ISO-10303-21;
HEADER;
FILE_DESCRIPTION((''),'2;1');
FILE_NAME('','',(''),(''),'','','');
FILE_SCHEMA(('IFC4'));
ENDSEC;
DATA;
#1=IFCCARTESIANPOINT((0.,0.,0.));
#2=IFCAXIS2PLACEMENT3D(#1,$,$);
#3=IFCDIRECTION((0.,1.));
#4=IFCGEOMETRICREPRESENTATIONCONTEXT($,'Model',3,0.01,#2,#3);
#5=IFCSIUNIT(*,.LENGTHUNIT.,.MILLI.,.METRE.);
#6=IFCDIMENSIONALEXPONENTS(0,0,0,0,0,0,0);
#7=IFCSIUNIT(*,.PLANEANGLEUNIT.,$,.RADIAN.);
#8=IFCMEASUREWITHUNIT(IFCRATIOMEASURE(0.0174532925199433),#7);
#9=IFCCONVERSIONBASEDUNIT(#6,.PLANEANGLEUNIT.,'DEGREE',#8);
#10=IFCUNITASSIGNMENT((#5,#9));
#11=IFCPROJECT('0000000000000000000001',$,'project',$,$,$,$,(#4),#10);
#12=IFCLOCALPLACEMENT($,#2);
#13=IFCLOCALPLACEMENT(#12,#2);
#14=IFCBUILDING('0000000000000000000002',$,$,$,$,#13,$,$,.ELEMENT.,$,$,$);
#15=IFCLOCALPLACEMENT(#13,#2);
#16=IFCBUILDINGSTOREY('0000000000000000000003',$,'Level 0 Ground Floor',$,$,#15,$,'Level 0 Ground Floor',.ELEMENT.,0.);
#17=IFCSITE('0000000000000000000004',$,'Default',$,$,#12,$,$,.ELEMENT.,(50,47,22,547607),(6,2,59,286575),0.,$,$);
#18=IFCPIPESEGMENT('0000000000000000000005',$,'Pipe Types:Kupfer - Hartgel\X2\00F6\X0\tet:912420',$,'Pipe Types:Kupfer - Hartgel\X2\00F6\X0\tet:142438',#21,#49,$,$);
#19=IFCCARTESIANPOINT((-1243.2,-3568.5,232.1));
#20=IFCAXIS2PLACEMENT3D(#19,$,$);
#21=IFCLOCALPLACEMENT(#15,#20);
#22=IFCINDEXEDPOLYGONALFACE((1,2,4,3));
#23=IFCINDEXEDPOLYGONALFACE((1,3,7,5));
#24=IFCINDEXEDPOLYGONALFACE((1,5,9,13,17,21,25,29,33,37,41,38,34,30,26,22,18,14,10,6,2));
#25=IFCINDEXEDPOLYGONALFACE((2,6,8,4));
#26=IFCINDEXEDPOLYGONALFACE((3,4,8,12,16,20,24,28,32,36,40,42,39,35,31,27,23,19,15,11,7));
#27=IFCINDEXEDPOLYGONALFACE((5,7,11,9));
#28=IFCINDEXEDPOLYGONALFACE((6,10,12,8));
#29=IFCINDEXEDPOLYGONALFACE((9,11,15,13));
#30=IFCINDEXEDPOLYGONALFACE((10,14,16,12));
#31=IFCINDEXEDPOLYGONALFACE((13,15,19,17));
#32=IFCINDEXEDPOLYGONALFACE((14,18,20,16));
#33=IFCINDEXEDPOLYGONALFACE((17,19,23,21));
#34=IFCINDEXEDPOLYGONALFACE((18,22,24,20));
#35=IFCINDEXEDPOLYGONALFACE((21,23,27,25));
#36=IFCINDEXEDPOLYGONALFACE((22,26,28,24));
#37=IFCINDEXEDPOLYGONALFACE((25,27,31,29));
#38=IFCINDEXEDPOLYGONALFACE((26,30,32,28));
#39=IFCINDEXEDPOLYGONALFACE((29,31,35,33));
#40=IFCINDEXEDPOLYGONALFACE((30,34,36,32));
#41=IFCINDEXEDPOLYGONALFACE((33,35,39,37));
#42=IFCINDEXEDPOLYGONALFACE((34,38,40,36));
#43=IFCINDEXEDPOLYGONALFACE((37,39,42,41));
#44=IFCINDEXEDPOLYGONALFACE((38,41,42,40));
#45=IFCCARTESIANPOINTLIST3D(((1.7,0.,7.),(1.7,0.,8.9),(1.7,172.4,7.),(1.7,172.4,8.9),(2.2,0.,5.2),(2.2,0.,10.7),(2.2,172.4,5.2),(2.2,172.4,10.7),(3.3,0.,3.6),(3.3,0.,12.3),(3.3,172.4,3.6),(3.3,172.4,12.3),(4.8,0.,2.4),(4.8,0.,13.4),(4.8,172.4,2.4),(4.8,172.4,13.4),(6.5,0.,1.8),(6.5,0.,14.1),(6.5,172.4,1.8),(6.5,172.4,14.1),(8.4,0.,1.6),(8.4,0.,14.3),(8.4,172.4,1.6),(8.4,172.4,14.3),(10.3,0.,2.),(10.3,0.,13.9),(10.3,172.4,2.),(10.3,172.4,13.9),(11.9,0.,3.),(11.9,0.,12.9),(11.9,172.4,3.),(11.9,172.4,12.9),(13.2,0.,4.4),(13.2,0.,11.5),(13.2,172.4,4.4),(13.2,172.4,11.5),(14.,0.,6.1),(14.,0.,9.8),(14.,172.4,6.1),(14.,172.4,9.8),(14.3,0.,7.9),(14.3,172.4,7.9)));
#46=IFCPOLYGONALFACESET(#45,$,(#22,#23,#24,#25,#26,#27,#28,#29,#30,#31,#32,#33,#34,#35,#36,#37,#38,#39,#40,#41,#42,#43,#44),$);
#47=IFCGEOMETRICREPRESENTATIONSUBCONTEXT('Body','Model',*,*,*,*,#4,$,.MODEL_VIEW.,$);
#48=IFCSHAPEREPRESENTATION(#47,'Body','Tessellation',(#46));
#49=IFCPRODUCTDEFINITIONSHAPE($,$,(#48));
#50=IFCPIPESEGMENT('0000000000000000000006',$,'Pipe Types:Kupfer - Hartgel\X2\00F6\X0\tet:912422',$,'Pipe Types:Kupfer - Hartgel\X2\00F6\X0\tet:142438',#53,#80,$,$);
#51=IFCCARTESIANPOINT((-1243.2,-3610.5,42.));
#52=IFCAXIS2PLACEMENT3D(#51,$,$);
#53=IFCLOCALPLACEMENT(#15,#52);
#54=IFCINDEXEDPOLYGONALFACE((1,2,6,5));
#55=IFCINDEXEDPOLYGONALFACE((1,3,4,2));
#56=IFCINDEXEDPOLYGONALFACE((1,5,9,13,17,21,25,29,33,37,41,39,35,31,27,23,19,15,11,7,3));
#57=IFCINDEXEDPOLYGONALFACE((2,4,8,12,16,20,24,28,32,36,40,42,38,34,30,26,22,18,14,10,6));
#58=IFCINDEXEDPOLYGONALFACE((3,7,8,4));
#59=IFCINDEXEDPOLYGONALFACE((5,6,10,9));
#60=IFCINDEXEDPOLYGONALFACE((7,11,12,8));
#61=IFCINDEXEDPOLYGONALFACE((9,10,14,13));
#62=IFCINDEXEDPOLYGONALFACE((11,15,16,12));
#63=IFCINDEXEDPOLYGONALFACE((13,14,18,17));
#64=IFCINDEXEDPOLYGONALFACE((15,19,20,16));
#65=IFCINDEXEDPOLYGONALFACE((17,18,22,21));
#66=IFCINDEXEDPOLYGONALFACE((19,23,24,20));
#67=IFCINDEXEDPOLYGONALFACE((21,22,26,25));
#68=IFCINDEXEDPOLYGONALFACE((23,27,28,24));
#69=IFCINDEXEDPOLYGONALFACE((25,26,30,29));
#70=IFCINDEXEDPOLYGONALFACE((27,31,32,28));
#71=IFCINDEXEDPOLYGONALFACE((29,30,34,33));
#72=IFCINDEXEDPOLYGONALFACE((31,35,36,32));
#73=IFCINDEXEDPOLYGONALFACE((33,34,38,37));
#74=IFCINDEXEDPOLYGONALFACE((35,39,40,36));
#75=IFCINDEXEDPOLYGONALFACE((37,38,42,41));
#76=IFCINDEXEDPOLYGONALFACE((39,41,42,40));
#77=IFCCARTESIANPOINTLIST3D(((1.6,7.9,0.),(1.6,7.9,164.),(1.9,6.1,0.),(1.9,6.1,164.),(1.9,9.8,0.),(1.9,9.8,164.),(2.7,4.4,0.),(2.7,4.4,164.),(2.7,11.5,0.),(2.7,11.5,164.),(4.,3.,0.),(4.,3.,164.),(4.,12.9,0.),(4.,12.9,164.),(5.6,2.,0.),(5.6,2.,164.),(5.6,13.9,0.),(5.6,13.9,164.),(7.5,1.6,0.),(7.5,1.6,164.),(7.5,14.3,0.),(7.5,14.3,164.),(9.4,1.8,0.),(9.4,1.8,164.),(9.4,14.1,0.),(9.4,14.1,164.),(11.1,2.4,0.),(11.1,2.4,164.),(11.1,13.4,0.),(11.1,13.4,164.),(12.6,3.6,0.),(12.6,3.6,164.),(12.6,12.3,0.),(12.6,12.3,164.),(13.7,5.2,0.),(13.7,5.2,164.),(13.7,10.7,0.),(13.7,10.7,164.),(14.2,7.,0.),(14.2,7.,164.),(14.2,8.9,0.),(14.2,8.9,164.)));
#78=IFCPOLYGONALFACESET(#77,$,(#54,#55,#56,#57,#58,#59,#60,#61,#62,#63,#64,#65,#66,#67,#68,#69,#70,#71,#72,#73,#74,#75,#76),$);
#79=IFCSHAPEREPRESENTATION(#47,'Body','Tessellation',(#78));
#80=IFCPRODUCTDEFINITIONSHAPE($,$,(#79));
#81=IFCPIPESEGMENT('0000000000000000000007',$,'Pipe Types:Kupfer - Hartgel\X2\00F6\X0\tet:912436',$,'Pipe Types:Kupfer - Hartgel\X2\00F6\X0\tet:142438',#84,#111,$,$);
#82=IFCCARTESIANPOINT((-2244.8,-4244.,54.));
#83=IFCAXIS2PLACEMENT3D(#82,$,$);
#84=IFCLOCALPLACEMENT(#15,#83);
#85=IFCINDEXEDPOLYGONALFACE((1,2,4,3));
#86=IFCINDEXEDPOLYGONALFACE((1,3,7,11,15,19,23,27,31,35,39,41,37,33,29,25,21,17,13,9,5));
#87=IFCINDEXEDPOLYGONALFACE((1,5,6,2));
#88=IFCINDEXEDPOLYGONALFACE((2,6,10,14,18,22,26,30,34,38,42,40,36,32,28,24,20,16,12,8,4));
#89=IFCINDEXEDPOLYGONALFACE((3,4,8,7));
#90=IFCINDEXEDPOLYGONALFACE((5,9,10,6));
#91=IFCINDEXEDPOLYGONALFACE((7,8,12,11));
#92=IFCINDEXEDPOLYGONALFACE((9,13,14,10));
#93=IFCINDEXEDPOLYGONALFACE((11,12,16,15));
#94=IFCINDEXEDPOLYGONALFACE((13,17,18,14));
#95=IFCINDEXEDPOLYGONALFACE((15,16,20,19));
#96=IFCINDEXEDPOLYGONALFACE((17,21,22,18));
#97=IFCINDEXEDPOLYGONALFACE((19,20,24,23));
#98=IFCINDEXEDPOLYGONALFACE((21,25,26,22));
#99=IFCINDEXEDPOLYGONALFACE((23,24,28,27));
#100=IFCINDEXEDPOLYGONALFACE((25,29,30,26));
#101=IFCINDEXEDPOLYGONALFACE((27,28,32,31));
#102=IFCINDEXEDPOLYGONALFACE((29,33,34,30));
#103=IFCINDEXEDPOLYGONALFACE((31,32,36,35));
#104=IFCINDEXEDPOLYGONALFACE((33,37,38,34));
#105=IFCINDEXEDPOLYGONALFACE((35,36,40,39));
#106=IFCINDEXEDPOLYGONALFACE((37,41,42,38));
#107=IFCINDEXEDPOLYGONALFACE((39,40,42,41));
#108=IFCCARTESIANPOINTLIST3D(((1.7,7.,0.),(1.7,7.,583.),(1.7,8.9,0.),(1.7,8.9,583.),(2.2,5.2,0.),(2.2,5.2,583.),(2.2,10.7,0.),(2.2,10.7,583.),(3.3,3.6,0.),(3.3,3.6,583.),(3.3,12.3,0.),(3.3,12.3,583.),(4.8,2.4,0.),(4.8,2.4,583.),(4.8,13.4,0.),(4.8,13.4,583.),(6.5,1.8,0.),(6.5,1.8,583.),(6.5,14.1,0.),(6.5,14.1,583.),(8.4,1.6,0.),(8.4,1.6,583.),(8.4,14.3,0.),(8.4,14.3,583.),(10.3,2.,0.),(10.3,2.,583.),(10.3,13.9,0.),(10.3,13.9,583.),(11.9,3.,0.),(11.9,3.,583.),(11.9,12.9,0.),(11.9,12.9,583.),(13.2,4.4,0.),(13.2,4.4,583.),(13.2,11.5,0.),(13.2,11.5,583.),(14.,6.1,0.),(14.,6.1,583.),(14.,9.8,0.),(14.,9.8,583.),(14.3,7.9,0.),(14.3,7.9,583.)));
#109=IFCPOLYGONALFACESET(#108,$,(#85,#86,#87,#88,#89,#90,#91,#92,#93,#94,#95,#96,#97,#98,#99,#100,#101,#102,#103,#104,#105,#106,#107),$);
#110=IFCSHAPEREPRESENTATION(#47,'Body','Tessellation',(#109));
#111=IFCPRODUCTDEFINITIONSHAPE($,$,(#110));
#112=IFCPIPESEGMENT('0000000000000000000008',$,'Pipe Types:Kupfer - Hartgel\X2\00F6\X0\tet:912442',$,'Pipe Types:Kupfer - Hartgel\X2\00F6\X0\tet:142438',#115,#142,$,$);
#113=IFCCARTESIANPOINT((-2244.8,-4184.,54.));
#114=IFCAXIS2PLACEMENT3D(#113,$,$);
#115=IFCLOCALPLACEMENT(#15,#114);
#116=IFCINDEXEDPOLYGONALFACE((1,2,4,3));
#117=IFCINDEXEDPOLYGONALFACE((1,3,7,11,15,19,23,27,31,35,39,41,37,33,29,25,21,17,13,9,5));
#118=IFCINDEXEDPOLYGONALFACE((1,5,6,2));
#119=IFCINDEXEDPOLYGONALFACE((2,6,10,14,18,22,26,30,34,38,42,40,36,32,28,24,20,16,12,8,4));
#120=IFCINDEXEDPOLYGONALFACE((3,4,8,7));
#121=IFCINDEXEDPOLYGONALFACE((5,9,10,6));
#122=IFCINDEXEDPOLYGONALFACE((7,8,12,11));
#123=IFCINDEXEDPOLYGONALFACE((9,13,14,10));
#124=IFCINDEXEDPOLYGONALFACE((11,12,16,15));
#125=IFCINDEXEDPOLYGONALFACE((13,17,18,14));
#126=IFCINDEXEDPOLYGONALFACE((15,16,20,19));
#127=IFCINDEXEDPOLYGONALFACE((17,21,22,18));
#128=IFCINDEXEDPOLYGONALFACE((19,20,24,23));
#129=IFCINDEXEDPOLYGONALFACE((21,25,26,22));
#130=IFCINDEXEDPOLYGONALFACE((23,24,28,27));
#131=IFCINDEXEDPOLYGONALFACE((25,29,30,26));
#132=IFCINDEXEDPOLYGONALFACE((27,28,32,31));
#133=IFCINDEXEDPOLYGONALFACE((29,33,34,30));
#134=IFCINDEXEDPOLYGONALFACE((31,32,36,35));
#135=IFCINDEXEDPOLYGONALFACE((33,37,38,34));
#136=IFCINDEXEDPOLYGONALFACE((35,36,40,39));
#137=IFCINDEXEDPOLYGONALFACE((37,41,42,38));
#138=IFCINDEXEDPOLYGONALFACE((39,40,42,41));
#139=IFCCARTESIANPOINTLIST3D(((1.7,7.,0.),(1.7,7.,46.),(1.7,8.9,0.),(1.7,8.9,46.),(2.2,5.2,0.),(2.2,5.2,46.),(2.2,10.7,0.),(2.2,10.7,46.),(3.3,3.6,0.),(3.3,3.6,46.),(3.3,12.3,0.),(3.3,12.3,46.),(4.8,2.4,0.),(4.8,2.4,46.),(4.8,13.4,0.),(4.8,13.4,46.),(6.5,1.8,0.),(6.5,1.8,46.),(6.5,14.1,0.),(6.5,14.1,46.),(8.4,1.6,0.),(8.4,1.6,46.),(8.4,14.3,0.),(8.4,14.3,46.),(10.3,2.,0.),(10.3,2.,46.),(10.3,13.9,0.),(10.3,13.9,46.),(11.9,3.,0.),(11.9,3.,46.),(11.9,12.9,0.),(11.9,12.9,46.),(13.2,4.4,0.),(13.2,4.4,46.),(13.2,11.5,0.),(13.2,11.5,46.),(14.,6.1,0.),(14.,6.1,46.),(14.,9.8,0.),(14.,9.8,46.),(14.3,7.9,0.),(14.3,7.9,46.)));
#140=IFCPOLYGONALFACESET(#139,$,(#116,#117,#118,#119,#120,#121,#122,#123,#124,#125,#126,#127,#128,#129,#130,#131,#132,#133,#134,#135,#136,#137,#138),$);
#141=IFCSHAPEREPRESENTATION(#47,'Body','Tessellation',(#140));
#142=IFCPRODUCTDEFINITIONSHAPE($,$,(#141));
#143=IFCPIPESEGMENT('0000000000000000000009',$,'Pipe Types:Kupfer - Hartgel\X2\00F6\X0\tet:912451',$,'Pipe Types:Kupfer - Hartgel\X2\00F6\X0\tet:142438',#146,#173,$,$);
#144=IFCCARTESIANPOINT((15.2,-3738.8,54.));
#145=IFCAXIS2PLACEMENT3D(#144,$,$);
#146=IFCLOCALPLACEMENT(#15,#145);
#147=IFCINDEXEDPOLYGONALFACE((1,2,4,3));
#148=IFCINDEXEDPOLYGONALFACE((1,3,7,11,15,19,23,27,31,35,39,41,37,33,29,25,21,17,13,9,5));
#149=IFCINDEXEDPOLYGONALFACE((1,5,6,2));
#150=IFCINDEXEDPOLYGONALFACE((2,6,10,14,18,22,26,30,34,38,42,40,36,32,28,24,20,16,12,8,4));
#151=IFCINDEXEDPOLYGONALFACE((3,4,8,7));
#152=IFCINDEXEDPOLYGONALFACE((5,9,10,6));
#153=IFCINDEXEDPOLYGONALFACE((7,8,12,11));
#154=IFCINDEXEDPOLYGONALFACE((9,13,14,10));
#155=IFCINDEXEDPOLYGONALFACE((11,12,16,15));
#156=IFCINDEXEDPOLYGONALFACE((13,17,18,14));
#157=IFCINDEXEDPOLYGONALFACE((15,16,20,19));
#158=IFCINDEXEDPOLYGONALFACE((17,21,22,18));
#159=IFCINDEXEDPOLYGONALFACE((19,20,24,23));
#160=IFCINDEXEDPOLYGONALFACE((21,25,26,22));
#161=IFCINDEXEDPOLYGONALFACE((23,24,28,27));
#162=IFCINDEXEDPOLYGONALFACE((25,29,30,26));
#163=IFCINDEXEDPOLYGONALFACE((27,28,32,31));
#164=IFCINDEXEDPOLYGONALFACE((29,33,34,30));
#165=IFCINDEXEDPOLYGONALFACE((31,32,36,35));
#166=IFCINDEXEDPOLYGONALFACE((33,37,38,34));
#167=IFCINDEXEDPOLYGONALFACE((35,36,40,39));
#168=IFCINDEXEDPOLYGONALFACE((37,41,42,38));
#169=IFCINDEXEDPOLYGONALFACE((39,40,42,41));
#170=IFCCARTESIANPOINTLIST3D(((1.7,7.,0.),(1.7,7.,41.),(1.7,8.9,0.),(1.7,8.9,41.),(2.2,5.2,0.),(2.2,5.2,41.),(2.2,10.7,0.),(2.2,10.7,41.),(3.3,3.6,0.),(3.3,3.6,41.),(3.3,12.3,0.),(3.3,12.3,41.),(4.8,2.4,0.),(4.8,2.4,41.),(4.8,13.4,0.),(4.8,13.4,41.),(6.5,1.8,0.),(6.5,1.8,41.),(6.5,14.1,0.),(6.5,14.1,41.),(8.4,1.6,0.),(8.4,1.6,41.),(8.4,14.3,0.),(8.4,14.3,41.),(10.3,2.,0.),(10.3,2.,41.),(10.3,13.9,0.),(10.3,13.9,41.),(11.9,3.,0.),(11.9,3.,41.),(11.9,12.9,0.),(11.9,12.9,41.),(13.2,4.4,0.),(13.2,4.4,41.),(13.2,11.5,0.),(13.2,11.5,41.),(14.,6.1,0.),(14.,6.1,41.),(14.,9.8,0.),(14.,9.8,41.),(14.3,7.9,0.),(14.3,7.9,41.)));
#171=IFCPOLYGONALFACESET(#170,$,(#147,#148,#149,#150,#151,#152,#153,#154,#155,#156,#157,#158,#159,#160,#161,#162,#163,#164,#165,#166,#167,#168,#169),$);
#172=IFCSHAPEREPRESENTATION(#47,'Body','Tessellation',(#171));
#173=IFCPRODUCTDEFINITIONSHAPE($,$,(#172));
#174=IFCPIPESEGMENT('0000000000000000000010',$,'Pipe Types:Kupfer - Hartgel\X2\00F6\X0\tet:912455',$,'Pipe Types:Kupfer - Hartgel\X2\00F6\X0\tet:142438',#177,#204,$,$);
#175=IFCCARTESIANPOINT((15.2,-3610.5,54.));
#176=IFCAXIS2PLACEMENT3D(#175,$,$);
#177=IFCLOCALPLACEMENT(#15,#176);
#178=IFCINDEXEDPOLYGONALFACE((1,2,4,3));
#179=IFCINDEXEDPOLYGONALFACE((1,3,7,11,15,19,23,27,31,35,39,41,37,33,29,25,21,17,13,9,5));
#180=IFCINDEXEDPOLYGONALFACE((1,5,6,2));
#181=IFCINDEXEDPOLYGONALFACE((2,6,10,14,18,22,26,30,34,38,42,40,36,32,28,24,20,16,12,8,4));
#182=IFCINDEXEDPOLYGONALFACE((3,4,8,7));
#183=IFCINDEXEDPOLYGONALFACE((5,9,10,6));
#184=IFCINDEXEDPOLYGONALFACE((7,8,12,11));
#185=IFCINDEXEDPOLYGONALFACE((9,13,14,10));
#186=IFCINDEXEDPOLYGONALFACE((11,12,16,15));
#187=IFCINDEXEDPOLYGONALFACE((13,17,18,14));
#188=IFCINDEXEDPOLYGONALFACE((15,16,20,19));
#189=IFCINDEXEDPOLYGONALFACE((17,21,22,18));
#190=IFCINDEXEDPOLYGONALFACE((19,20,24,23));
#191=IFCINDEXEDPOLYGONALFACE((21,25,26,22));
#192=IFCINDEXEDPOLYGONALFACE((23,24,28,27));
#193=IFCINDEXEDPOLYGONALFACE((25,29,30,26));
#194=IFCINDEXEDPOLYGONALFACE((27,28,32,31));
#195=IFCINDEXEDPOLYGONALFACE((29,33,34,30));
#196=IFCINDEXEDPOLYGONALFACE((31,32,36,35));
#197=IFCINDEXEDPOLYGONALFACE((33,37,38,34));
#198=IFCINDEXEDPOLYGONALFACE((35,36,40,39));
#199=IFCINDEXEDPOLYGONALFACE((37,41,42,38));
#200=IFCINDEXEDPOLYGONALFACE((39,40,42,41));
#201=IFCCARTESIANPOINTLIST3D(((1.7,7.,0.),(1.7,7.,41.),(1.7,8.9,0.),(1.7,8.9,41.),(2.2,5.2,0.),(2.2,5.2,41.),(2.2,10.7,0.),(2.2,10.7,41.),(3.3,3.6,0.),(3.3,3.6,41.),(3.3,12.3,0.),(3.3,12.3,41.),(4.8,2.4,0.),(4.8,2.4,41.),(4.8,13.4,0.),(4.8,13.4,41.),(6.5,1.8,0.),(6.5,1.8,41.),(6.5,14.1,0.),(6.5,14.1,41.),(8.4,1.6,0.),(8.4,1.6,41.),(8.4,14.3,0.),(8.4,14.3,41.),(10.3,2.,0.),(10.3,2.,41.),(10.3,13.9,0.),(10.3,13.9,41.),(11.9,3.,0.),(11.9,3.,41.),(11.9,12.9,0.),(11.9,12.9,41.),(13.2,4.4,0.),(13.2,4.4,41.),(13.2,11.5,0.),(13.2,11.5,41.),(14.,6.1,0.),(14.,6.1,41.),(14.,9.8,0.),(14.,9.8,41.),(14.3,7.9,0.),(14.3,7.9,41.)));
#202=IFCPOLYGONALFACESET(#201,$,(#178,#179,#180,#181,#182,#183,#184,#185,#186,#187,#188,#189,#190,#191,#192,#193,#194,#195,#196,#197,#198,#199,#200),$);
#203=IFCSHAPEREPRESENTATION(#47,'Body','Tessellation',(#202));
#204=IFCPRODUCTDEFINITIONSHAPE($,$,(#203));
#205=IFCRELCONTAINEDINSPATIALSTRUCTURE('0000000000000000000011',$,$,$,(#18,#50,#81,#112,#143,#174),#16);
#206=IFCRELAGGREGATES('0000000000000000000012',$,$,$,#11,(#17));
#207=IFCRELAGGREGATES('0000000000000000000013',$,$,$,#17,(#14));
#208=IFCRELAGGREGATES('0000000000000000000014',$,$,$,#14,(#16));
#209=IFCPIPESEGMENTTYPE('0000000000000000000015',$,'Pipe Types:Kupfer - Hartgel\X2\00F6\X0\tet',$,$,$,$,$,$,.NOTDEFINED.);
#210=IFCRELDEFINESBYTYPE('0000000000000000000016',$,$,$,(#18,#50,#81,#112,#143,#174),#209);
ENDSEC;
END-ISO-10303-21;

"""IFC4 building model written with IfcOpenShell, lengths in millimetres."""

from ifc_helpers import new_model, entity, si_unit, converted_unit, direction, frame, frame_2d, origin, origin_2d_with_axis, place, context, subcontext, project, spatial, circle, extrude, type_object, element, save


model = new_model("IFC4")

# Units and contexts
model_context = context("Model", 3, precision=0.01, world=origin(), true_north=direction((0.0, 1.0)))
body_context = subcontext(model_context, "Body", "Model", "MODEL_VIEW")
ifc_project = project(units=[si_unit("LENGTHUNIT", "METRE", prefix="MILLI"), converted_unit("PLANEANGLEUNIT", "DEGREE", entity("IfcRatioMeasure", 0.0174532925199433), si_unit("PLANEANGLEUNIT", "RADIAN"), dimensions=[0, 0, 0, 0, 0, 0, 0])], contexts=[model_context])

# Site, building, storey
site_placement = place(None, origin())
site = spatial("IfcSite", under=ifc_project, at=site_placement, Name="Default", CompositionType="ELEMENT", RefLatitude=(50, 47, 22, 547607), RefLongitude=(6, 2, 59, 286575), RefElevation=0.0)
building_placement = place(site_placement, origin())
building = spatial("IfcBuilding", under=site, at=building_placement, CompositionType="ELEMENT")
storey_placement = place(building_placement, origin())
storey = spatial("IfcBuildingStorey", under=building, at=storey_placement, Name="Level 0 Ground Floor", LongName="Level 0 Ground Floor", CompositionType="ELEMENT", Elevation=0.0)

# Pipe segments
pipe_segment_type = type_object("IfcPipeSegmentType", Name="Pipe Types:Kupfer - Hartgelötet", PredefinedType="NOTDEFINED")
pipe_segment_1_placement = place(storey_placement, frame((-1243.2, -3568.5, 232.1)))
element("IfcPipeSegment", 1, at=pipe_segment_1_placement, inside=storey, type_object=pipe_segment_type, Name="Pipe Types:Kupfer - Hartgelötet:912420", ObjectType="Pipe Types:Kupfer - Hartgelötet:142438", context=body_context, shape_type="SweptSolid", body=[
    extrude(circle(Radius=6.3, at=frame_2d((0.0, 0.0), x_axis=(1.0, 0.0))), frame((7.9, 0.0, 7.9), z_axis=(0.0, 1.0, 0.0), x_axis=(1.0, 0.0, 0.0)), (0.0, 0.0, 1.0), 172.4),
])
pipe_segment_2_placement = place(storey_placement, frame((-1243.2, -3610.5, 42.0)))
element("IfcPipeSegment", 2, at=pipe_segment_2_placement, inside=storey, type_object=pipe_segment_type, Name="Pipe Types:Kupfer - Hartgelötet:912422", ObjectType="Pipe Types:Kupfer - Hartgelötet:142438", context=body_context, shape_type="SweptSolid", body=[
    extrude(circle(Radius=6.3, at=frame_2d((0.0, 0.0), x_axis=(1.0, 0.0))), frame((7.9, 7.9, 0.0), z_axis=(0.0, 0.0, 1.0), x_axis=(-1.0, 0.0, 0.0)), (0.0, 0.0, 1.0), 164.0),
])
pipe_segment_3_placement = place(storey_placement, frame((-2244.8, -4244.0, 54.0)))
element("IfcPipeSegment", 3, at=pipe_segment_3_placement, inside=storey, type_object=pipe_segment_type, Name="Pipe Types:Kupfer - Hartgelötet:912436", ObjectType="Pipe Types:Kupfer - Hartgelötet:142438", context=body_context, shape_type="SweptSolid", body=[
    extrude(circle(Radius=6.3, at=frame_2d((0.0, 0.0), x_axis=(1.0, 0.0))), frame((7.9, 7.9, 0.0)), (0.0, 0.0, 1.0), 583.0),
])
pipe_segment_4_placement = place(storey_placement, frame((-2244.8, -4184.0, 54.0)))
element("IfcPipeSegment", 4, at=pipe_segment_4_placement, inside=storey, type_object=pipe_segment_type, Name="Pipe Types:Kupfer - Hartgelötet:912442", ObjectType="Pipe Types:Kupfer - Hartgelötet:142438", context=body_context, shape_type="SweptSolid", body=[
    extrude(circle(Radius=6.3, at=origin_2d_with_axis()), frame((7.9, 7.9, 0.0)), (0.0, 0.0, 1.0), 46.0),
])
pipe_segment_5_placement = place(storey_placement, frame((15.2, -3738.8, 54.0)))
element("IfcPipeSegment", 5, at=pipe_segment_5_placement, inside=storey, type_object=pipe_segment_type, Name="Pipe Types:Kupfer - Hartgelötet:912451", ObjectType="Pipe Types:Kupfer - Hartgelötet:142438", context=body_context, shape_type="SweptSolid", body=[
    extrude(circle(Radius=6.3, at=frame_2d((0.0, 0.0), x_axis=(1.0, 0.0))), frame((7.9, 7.9, 0.0)), (0.0, 0.0, 1.0), 41.0),
])
pipe_segment_6_placement = place(storey_placement, frame((15.2, -3610.5, 54.0)))
element("IfcPipeSegment", 6, at=pipe_segment_6_placement, inside=storey, type_object=pipe_segment_type, Name="Pipe Types:Kupfer - Hartgelötet:912455", ObjectType="Pipe Types:Kupfer - Hartgelötet:142438", context=body_context, shape_type="SweptSolid", body=[
    extrude(circle(Radius=6.3, at=frame_2d((0.0, 0.0), x_axis=(1.0, 0.0))), frame((7.9, 7.9, 0.0)), (0.0, 0.0, 1.0), 41.0),
])

save(model, "model.ifc")
